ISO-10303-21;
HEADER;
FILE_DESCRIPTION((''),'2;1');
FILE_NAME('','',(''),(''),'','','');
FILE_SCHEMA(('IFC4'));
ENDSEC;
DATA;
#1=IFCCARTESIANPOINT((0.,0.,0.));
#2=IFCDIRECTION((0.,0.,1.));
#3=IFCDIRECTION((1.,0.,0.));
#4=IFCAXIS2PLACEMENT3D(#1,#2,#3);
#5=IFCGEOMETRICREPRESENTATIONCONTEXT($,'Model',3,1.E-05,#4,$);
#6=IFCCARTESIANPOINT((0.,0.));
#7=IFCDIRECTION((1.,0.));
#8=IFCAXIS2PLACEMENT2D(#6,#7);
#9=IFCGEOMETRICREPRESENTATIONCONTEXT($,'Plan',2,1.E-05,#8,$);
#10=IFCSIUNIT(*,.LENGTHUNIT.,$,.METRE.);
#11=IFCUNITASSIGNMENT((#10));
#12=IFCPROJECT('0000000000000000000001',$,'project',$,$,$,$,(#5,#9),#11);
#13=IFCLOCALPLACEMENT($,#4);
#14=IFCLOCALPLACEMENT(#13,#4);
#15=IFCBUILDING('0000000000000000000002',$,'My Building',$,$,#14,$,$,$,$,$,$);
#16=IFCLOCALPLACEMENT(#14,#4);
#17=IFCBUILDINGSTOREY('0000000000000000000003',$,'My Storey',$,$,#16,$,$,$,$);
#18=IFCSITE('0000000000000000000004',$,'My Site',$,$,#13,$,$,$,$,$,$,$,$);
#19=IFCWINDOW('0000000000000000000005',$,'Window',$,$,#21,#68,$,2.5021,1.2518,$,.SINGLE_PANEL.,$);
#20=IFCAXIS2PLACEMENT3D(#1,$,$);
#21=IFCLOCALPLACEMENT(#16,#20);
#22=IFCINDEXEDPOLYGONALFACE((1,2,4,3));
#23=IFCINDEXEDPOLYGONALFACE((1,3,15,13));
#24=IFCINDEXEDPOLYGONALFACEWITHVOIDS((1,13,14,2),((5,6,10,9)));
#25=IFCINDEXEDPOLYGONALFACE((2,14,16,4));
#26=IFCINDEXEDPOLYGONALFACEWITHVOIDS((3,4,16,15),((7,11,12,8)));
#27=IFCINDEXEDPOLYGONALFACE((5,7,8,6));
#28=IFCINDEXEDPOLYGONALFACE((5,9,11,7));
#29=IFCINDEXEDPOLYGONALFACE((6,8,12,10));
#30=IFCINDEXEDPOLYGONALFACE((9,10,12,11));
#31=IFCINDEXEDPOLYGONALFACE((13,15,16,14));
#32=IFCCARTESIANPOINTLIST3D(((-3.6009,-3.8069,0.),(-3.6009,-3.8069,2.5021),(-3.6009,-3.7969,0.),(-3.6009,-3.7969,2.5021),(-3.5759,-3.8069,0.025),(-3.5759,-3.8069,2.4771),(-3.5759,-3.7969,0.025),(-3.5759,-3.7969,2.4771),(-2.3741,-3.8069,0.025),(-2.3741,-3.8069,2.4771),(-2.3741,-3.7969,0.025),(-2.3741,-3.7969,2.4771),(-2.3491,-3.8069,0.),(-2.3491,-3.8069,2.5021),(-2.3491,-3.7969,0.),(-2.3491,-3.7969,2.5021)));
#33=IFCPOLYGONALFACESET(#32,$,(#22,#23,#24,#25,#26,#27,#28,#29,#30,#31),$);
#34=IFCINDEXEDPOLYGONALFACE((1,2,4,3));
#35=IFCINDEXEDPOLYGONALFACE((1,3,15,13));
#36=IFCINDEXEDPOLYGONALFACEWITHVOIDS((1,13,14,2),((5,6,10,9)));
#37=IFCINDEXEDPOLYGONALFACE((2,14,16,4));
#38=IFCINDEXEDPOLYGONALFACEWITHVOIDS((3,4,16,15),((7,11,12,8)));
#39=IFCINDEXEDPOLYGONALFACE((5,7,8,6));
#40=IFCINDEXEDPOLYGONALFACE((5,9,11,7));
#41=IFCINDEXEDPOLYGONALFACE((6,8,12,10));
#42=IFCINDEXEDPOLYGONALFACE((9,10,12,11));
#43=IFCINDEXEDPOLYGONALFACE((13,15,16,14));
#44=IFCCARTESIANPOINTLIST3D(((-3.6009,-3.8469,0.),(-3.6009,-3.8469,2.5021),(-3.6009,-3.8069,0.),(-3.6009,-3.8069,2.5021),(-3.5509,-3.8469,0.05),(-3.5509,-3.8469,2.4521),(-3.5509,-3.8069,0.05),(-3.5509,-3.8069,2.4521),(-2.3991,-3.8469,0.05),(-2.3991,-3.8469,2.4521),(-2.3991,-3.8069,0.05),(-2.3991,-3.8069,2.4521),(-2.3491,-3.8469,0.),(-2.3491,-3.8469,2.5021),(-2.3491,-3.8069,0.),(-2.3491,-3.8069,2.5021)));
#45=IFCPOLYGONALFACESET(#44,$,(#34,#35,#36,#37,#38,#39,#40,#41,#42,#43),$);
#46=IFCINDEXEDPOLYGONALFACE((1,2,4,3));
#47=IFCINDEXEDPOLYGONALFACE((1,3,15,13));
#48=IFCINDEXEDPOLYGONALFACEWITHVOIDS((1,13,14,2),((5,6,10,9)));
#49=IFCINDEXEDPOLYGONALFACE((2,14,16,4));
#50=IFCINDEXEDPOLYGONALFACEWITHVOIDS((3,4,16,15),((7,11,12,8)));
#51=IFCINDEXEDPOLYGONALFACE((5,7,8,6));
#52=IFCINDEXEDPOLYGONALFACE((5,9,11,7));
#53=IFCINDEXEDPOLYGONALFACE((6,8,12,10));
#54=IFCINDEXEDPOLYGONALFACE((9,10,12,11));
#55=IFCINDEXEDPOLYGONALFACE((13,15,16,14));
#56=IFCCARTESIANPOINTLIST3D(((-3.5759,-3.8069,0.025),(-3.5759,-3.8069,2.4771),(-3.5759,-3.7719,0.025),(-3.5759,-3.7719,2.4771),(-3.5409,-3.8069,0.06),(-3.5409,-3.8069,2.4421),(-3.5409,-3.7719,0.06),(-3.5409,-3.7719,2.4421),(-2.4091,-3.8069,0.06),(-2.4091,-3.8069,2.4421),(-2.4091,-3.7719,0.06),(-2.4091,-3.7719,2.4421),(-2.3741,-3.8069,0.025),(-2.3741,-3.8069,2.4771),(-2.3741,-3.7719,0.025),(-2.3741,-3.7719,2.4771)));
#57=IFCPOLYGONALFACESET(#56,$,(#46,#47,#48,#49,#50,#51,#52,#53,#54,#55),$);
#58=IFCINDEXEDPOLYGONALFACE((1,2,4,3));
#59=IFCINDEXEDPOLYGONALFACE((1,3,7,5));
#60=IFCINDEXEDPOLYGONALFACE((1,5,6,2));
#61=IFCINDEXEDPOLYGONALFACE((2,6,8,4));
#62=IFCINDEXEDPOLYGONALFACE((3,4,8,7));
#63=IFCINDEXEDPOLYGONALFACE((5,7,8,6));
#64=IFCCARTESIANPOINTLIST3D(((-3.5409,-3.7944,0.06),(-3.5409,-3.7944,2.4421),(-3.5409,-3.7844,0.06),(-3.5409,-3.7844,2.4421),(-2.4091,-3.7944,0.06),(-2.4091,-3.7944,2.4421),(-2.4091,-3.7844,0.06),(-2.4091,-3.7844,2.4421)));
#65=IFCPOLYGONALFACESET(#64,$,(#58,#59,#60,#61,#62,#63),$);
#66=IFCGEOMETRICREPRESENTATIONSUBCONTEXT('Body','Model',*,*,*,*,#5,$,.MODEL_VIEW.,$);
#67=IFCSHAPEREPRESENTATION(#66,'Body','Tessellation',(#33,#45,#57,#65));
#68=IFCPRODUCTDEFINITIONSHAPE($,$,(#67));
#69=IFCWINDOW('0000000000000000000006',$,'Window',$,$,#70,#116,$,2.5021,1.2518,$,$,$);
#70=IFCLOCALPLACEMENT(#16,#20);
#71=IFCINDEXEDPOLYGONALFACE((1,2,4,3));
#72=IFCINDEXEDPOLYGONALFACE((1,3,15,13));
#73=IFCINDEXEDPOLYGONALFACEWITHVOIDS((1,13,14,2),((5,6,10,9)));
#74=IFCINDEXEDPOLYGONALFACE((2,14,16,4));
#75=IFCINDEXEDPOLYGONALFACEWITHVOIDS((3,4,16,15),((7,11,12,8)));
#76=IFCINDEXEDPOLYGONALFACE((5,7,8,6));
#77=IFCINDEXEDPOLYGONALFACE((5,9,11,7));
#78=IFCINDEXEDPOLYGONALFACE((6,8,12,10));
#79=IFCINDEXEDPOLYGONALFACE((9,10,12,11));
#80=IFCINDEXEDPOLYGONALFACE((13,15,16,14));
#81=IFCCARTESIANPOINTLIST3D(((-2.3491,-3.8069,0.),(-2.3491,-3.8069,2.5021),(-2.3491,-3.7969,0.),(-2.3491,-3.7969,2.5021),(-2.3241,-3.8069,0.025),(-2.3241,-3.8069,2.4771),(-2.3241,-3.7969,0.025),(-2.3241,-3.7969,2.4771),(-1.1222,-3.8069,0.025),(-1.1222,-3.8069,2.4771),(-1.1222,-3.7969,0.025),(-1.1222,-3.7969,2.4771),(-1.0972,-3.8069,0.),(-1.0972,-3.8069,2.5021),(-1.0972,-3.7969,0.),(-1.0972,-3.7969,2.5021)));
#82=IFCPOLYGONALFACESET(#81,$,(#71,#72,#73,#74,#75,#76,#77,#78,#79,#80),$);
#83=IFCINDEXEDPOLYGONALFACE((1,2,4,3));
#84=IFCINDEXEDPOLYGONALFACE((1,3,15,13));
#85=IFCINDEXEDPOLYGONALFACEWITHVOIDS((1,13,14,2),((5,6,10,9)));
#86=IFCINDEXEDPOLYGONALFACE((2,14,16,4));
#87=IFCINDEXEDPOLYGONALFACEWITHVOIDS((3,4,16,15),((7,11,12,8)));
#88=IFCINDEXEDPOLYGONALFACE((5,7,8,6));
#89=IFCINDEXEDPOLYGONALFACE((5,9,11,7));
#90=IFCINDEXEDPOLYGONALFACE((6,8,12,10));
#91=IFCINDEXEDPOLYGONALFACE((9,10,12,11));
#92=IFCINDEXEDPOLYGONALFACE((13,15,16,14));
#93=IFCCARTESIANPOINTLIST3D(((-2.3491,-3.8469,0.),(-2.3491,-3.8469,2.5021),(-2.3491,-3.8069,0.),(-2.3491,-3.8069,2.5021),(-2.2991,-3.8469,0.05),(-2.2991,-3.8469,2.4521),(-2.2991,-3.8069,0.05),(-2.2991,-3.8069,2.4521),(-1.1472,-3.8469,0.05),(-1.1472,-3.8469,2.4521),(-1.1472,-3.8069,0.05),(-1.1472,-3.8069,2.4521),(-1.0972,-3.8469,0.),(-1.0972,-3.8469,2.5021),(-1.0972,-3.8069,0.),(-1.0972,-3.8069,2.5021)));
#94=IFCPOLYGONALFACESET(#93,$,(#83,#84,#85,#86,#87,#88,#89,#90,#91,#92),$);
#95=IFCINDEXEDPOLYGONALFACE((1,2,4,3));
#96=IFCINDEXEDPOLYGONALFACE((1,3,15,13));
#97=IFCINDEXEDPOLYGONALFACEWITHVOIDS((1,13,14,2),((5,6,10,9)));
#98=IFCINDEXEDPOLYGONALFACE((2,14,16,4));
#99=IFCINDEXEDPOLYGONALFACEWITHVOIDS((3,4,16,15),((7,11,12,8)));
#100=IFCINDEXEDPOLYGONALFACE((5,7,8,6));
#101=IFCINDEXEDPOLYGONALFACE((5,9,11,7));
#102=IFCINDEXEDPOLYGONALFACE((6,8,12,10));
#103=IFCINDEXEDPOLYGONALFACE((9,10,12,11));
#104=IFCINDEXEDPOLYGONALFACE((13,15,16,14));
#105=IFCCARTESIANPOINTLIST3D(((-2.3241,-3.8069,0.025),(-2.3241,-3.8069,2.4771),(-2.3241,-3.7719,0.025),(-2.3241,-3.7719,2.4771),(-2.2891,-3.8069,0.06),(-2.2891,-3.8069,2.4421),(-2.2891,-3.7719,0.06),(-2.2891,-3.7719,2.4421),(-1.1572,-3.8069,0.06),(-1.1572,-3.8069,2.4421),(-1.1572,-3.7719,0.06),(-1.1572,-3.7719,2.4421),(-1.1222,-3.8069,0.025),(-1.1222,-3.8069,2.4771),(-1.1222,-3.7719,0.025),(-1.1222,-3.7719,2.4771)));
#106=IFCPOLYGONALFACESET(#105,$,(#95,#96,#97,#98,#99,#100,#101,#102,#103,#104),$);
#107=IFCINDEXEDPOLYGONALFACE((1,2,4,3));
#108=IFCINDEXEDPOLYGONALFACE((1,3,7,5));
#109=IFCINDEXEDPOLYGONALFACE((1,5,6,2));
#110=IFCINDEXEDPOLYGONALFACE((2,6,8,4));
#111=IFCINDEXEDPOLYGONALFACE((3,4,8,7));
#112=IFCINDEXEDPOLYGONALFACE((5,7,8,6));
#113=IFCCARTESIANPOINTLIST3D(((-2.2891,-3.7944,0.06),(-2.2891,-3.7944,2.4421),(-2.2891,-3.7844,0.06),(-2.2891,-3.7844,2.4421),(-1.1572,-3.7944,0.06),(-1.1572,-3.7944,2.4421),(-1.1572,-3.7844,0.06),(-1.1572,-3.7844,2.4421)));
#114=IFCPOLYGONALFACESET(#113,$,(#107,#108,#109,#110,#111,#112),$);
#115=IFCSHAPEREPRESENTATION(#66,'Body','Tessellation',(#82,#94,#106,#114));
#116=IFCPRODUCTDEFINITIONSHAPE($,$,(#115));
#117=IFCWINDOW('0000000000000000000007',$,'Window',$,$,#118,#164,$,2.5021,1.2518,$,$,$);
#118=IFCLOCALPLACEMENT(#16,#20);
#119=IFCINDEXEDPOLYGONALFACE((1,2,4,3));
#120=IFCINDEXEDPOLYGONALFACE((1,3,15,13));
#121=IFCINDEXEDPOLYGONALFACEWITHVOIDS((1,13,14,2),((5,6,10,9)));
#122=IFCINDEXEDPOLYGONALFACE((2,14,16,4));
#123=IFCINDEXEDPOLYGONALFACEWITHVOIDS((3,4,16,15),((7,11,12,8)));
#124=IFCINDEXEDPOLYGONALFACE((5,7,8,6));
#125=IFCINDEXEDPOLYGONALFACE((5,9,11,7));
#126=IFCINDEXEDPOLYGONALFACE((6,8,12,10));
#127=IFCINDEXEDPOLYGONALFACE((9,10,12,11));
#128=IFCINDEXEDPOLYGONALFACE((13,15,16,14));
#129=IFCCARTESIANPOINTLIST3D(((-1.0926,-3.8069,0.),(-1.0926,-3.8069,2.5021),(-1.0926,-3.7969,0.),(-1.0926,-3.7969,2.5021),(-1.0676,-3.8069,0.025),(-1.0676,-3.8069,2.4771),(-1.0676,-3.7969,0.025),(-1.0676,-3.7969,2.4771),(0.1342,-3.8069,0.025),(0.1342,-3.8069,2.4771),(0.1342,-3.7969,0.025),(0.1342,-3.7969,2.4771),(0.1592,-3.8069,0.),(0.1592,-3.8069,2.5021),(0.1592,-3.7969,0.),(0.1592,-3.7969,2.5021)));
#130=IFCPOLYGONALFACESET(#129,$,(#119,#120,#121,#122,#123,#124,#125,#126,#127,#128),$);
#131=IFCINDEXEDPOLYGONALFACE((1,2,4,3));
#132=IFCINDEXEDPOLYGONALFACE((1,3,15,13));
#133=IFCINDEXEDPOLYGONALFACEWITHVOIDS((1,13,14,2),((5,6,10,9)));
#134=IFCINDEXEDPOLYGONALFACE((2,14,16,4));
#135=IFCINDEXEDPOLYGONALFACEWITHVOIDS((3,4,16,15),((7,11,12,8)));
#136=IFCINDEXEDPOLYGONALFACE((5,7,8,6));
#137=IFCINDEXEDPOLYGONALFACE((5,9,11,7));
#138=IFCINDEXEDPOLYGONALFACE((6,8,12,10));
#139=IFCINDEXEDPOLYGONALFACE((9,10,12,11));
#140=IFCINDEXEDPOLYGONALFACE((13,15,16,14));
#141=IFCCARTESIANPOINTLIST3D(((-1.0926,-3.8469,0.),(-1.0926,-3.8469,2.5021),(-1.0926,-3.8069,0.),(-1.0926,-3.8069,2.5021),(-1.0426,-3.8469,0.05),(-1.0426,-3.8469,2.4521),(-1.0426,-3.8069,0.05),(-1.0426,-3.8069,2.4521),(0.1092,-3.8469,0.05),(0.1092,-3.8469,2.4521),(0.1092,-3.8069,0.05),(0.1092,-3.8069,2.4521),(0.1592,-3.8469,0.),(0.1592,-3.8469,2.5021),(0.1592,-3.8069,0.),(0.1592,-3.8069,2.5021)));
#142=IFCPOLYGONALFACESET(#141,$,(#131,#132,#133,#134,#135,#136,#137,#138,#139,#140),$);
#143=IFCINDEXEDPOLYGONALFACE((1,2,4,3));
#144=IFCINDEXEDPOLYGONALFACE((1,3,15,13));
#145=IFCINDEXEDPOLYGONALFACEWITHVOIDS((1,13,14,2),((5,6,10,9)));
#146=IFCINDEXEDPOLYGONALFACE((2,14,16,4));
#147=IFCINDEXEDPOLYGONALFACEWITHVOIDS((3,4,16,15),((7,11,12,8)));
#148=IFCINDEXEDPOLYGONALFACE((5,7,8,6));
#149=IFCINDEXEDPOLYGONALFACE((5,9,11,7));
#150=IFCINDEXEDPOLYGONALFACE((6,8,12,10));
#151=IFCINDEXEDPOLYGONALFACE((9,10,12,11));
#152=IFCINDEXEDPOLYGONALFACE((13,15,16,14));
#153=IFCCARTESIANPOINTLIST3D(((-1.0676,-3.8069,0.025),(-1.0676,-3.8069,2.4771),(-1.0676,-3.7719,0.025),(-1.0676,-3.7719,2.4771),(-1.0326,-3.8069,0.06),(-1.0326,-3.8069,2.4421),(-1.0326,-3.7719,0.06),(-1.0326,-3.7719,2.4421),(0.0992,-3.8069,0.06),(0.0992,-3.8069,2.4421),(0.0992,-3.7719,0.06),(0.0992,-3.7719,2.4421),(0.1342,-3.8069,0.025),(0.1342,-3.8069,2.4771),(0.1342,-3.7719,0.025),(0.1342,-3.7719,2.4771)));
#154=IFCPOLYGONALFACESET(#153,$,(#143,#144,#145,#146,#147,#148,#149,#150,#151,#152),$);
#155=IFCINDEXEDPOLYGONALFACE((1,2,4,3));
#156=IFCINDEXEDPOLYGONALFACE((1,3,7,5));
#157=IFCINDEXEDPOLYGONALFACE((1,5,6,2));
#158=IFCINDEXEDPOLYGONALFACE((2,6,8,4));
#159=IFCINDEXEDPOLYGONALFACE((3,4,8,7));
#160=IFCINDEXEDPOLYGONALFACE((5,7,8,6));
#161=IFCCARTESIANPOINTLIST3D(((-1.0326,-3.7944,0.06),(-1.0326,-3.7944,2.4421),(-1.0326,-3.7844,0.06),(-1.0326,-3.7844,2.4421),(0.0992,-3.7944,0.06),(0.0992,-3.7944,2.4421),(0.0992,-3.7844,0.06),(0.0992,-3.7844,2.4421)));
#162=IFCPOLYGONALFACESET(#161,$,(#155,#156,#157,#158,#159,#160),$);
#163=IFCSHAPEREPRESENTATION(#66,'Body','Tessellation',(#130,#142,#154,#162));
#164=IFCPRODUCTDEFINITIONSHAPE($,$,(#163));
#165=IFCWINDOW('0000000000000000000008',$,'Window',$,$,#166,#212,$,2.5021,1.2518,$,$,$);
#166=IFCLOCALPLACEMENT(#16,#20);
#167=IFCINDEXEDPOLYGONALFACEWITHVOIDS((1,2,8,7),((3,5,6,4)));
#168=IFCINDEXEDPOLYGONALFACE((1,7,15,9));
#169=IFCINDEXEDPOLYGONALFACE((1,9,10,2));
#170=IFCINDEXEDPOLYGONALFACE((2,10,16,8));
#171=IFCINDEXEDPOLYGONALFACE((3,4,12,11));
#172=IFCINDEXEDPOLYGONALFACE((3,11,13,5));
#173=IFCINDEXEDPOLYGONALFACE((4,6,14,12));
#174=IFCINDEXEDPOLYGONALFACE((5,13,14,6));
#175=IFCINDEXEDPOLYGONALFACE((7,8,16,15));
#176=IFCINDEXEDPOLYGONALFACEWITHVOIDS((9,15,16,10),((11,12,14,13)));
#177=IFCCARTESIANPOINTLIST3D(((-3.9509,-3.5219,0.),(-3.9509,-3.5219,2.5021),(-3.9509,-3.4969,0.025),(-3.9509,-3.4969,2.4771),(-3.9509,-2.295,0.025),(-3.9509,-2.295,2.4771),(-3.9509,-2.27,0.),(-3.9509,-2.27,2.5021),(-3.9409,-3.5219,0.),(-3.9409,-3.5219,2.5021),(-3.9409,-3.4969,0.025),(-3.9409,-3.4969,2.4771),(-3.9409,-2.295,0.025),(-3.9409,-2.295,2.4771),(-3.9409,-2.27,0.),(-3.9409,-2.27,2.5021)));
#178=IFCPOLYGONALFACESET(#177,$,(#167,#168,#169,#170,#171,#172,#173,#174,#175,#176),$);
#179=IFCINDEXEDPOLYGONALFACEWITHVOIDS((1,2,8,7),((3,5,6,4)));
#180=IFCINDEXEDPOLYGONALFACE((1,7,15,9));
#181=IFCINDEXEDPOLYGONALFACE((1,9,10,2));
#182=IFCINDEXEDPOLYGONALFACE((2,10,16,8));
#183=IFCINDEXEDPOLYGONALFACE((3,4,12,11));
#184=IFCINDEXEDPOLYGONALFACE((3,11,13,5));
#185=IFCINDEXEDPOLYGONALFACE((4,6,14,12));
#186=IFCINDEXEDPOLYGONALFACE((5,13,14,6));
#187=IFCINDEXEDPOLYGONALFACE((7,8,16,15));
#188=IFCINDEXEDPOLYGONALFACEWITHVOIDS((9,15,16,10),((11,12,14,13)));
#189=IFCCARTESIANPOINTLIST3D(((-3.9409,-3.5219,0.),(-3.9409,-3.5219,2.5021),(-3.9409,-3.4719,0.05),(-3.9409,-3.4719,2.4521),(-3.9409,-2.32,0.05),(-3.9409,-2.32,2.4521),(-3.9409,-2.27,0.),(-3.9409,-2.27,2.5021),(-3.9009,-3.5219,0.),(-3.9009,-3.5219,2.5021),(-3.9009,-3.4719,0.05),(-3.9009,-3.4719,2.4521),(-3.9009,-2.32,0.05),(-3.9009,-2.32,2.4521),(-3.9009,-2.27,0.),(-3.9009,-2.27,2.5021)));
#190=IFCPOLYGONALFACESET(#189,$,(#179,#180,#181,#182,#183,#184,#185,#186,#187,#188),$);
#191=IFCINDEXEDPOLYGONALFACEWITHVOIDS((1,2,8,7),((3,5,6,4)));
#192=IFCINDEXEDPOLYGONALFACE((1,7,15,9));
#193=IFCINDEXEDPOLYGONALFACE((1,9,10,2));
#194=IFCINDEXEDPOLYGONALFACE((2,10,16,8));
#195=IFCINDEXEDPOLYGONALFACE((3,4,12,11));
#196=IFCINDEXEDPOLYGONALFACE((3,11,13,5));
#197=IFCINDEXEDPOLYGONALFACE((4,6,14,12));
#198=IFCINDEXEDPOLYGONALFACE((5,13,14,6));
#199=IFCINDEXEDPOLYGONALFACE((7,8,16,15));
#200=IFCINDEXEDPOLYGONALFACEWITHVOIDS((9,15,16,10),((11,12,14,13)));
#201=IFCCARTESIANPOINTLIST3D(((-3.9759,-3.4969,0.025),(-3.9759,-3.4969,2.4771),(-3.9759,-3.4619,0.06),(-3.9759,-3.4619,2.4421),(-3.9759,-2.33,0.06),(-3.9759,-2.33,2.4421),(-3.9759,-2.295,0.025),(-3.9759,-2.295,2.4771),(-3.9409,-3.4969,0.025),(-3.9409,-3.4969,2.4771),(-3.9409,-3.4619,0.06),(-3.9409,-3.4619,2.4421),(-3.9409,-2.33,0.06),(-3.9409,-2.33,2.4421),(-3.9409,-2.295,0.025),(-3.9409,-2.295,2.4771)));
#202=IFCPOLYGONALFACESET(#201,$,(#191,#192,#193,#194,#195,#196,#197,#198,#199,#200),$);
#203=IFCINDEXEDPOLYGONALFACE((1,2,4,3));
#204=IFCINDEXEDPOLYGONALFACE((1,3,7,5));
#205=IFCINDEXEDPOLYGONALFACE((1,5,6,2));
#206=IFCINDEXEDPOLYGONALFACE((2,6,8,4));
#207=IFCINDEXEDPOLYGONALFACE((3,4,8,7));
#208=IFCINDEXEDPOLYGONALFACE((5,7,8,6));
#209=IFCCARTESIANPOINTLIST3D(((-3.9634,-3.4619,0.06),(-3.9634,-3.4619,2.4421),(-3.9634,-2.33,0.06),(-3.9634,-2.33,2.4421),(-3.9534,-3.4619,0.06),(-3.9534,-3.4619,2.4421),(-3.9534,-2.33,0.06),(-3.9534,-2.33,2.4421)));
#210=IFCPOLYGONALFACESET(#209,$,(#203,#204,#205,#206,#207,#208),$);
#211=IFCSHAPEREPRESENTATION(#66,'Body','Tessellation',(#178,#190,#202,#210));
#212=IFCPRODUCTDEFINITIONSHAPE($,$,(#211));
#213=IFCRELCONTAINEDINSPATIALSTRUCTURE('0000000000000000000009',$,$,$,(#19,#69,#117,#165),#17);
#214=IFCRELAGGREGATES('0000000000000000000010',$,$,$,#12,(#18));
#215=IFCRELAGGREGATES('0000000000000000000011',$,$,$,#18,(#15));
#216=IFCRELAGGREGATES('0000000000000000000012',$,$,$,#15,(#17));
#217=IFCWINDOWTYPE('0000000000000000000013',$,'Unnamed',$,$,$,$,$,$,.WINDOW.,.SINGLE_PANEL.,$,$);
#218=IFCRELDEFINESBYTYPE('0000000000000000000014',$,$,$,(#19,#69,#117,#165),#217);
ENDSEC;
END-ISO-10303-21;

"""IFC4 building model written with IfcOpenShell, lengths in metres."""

from ifc_helpers import new_model, entity, si_unit, frame, origin_with_axes, origin_2d_with_axis, place, context, subcontext, project, spatial, line, indexed_curve, outline, extrude, shape, source, transform, mapped, type_object, type_shapes, element, save


model = new_model("IFC4")

# Units and contexts
model_context = context("Model", 3, precision=1e-05, world=origin_with_axes())
plan_context = context("Plan", 2, precision=1e-05, world=origin_2d_with_axis())
body_context_1 = subcontext(model_context, "Body", "Model", "MODEL_VIEW")
body_context_2 = subcontext(plan_context, "Body", "Plan", "PLAN_VIEW")
ifc_project = project(units=[si_unit("LENGTHUNIT", "METRE")], contexts=[model_context, plan_context])

# Site, building, storey
site_placement = place(None, origin_with_axes())
site = spatial("IfcSite", under=ifc_project, at=site_placement, Name="My Site")
building_placement = place(site_placement, origin_with_axes())
building = spatial("IfcBuilding", under=site, at=building_placement, Name="My Building")
storey_placement = place(building_placement, origin_with_axes())
storey = spatial("IfcBuildingStorey", under=building, at=storey_placement, Name="My Storey")

# Windows
window_type = type_object("IfcWindowType", Name="Unnamed", PartitioningType="SINGLE_PANEL", PredefinedType="WINDOW")
shared_shape_1 = source(origin_with_axes(), body_context_1, "Body", "SweptSolid", [
    extrude(outline(indexed_curve([(0.0, 0.0), (1.2518, 0.0), (1.2518, 2.5021), (0.0, 2.5021)], segments=[line(1, 2, 3, 4, 1)]), holes=[indexed_curve([(0.025, 0.025), (1.2268, 0.025), (1.2268, 2.4771), (0.025, 2.4771)], segments=[line(1, 2, 3, 4, 1)])]), frame((0.0, 0.09, 0.0), z_axis=(0.0, -1.0, 0.0), x_axis=(1.0, 0.0, 0.0)), (0.0, 0.0, -1.0), 0.01),
    extrude(outline(indexed_curve([(0.0, 0.0), (1.2518, 0.0), (1.2518, 2.5021), (0.0, 2.5021)], segments=[line(1, 2, 3, 4, 1)]), holes=[indexed_curve([(0.05, 0.05), (1.2018, 0.05), (1.2018, 2.4521), (0.05, 2.4521)], segments=[line(1, 2, 3, 4, 1)])]), frame((0.0, 0.05, 0.0), z_axis=(0.0, -1.0, 0.0), x_axis=(1.0, 0.0, 0.0)), (0.0, 0.0, -1.0), 0.04),
    extrude(outline(indexed_curve([(0.0, 0.0), (1.2018, 0.0), (1.2018, 2.4521), (0.0, 2.4521)], segments=[line(1, 2, 3, 4, 1)]), holes=[indexed_curve([(0.035, 0.035), (1.1668, 0.035), (1.1668, 2.4171), (0.035, 2.4171)], segments=[line(1, 2, 3, 4, 1)])]), frame((0.025, 0.09, 0.025), z_axis=(0.0, -1.0, 0.0), x_axis=(1.0, 0.0, 0.0)), (0.0, 0.0, -1.0), 0.035),
    extrude(outline(indexed_curve([(0.035, 0.035), (1.1668, 0.035), (1.1668, 2.4171), (0.035, 2.4171)], segments=[line(1, 2, 3, 4, 1)])), frame((0.025, 0.1025, 0.025), z_axis=(0.0, -1.0, 0.0), x_axis=(1.0, 0.0, 0.0)), (0.0, 0.0, -1.0), 0.01),
])
shared_shape_2 = source(origin_with_axes(), body_context_2, "Body", "Curve2D", [
    entity("IfcIndexedPolyCurve", entity("IfcCartesianPointList2D", [[0.05, 0.05], [1.2018, 0.05]])),
    entity("IfcIndexedPolyCurve", entity("IfcCartesianPointList2D", [[0.0, 0.1], [0.025, 0.1], [0.025, 0.09], [0.05, 0.09], [0.05, 0.05], [0.0, 0.05]]), [entity("IfcLineIndex", [1, 2, 3, 4, 5, 6, 1])]),
    entity("IfcIndexedPolyCurve", entity("IfcCartesianPointList2D", [[1.2518, 0.1], [1.2268, 0.1], [1.2268, 0.09], [1.2018, 0.09], [1.2018, 0.05], [1.2518, 0.05]]), [entity("IfcLineIndex", [1, 2, 3, 4, 5, 6, 1])]),
    entity("IfcIndexedPolyCurve", entity("IfcCartesianPointList2D", [[0.025, 0.09], [0.06, 0.09], [0.06, 0.125], [0.025, 0.125]]), [entity("IfcLineIndex", [1, 2, 3, 4, 1])]),
    entity("IfcIndexedPolyCurve", entity("IfcCartesianPointList2D", [[1.2268, 0.09], [1.1918, 0.09], [1.1918, 0.125], [1.2268, 0.125]]), [entity("IfcLineIndex", [1, 2, 3, 4, 1])]),
    entity("IfcIndexedPolyCurve", entity("IfcCartesianPointList2D", [[0.06, 0.09], [1.1918, 0.09]])),
    entity("IfcIndexedPolyCurve", entity("IfcCartesianPointList2D", [[0.06, 0.125], [1.1918, 0.125]])),
    entity("IfcIndexedPolyCurve", entity("IfcCartesianPointList2D", [[0.06, 0.1075], [1.1918, 0.1075]])),
])
type_shapes(window_type, [shared_shape_1, shared_shape_2])
window_placement = place(storey_placement, frame((-3.6009, -3.8969, 0.0), z_axis=(0.0, 0.0, 1.0), x_axis=(1.0, 0.0, 0.0)))
element("IfcWindow", 1, at=window_placement, inside=storey, type_object=window_type, Name="Window", OverallHeight=2.5021, OverallWidth=1.2518, PartitioningType="SINGLE_PANEL", shapes=[
    shape(body_context_1, "Body", "MappedRepresentation", [mapped(shared_shape_1, transform((0.0, 0.0, 0.0), x_axis=(1.0, 0.0, 0.0), y_axis=(0.0, 1.0, 0.0), z_axis=(0.0, 0.0, 1.0), scale=1.0))]),
    shape(body_context_2, "Body", "MappedRepresentation", [mapped(shared_shape_2, transform((0.0, 0.0, 0.0), x_axis=(1.0, 0.0, 0.0), y_axis=(0.0, 1.0, 0.0), z_axis=(0.0, 0.0, 1.0), scale=1.0))]),
])
for number, where, z_axis, x_axis, name in (
    (2, (-2.3491, -3.8969, 0.0), (0.0, 0.0, 1.0), (1.0, 0.0, 0.0), "Window"),
    (3, (-1.0926, -3.8969, 0.0), (0.0, 0.0, 1.0), (1.0, 0.0, 0.0), "Window"),
    (4, (-3.8509, -3.5219, 0.0), (0.0, 0.0, 1.0), (0.0, 1.0, 0.0), "Window"),
):
    element("IfcWindow", number, at=place(storey_placement, frame(where, z_axis=z_axis, x_axis=x_axis)), inside=storey, type_object=window_type, Name=name, OverallHeight=2.5021, OverallWidth=1.2518, shapes=[
        shape(body_context_1, "Body", "MappedRepresentation", [mapped(shared_shape_1, transform((0.0, 0.0, 0.0), x_axis=(1.0, 0.0, 0.0), y_axis=(0.0, 1.0, 0.0), z_axis=(0.0, 0.0, 1.0), scale=1.0))]),
        shape(body_context_2, "Body", "MappedRepresentation", [mapped(shared_shape_2, transform((0.0, 0.0, 0.0), x_axis=(1.0, 0.0, 0.0), y_axis=(0.0, 1.0, 0.0), z_axis=(0.0, 0.0, 1.0), scale=1.0))]),
    ])

save(model, "model.ifc")
